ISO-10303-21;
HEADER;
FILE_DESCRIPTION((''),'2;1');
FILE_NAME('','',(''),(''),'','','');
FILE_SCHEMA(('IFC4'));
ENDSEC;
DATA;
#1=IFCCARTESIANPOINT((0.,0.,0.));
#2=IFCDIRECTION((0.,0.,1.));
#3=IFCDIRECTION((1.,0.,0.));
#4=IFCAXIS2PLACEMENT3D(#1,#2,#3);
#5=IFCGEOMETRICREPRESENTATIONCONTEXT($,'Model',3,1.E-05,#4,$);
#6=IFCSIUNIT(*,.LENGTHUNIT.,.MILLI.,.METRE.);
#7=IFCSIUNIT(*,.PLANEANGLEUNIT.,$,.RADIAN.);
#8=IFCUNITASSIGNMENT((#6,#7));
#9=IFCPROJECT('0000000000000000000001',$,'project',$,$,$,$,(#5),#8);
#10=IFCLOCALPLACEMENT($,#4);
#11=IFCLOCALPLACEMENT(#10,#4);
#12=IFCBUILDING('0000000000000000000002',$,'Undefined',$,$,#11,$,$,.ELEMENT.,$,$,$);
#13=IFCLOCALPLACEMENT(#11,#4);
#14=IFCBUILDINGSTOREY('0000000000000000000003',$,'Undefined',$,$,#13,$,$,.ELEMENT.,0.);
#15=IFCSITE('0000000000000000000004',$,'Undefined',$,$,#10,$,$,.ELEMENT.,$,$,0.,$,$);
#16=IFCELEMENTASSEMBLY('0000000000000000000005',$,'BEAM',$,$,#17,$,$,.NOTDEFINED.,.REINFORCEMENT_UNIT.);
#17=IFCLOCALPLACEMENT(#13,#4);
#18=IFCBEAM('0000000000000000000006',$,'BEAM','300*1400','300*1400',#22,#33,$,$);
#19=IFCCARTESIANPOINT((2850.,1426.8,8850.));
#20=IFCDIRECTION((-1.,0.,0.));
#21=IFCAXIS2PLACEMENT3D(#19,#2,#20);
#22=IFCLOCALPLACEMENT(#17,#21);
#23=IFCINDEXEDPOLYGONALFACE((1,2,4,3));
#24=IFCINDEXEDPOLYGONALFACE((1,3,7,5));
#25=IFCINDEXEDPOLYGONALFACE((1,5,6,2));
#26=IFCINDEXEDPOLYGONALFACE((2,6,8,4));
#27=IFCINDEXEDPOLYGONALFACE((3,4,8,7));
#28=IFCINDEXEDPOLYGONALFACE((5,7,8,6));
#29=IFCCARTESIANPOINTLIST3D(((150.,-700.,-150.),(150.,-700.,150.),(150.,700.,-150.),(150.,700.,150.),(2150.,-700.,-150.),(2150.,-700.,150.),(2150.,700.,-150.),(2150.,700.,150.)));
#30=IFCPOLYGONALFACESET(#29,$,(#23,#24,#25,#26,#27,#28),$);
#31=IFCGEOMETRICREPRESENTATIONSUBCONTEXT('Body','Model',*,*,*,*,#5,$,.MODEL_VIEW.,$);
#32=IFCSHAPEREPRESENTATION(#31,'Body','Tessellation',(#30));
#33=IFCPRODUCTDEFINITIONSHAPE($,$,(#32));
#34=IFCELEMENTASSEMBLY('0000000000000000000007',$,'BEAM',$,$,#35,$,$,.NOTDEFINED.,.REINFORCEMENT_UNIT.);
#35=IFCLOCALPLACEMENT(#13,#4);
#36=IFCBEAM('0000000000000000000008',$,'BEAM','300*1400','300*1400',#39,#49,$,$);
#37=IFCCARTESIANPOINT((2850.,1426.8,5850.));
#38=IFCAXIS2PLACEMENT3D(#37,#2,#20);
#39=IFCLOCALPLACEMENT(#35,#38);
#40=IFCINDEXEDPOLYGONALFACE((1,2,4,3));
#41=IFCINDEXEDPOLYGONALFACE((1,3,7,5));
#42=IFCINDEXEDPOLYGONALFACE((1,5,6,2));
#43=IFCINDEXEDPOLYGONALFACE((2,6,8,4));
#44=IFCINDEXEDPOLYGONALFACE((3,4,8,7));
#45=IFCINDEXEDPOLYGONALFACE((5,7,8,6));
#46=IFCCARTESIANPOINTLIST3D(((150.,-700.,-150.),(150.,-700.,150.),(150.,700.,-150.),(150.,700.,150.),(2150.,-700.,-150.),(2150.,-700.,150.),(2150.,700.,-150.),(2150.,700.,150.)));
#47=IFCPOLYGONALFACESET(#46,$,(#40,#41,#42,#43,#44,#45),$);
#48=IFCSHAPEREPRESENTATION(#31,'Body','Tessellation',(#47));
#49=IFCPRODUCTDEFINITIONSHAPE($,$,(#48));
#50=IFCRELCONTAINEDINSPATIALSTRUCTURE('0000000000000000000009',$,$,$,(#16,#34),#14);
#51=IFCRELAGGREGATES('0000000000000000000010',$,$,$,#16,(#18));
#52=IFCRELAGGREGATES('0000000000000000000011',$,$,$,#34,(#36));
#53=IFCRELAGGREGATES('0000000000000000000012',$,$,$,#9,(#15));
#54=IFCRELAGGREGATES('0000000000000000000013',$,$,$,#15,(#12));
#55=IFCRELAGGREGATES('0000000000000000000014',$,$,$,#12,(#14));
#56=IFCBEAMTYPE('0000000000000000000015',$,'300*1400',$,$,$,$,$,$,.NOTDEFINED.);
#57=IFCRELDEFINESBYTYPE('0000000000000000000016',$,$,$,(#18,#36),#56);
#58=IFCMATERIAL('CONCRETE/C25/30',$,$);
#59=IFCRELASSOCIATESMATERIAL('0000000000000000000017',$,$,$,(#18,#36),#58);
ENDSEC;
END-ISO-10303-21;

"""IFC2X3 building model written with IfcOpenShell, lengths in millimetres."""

from ifc_helpers import new_model, si_unit, frame, origin_with_axes, origin_2d_with_axis, place, context, subcontext, project, spatial, rectangle, extrude, material, type_object, element, aggregate, save


model = new_model("IFC2X3")

# Units and contexts
model_context = context("Model", 3, precision=1e-05, world=origin_with_axes())
body_context = subcontext(model_context, "Body", "Model", "MODEL_VIEW")
ifc_project = project(units=[si_unit("LENGTHUNIT", "METRE", prefix="MILLI"), si_unit("PLANEANGLEUNIT", "RADIAN")], contexts=[model_context])

# Site, building, storey
site_placement = place(None, origin_with_axes())
site = spatial("IfcSite", under=ifc_project, at=site_placement, Name="Undefined", CompositionType="ELEMENT", RefElevation=0.0)
building_placement = place(site_placement, origin_with_axes())
building = spatial("IfcBuilding", under=site, at=building_placement, Name="Undefined", CompositionType="ELEMENT")
storey_placement = place(building_placement, origin_with_axes())
storey = spatial("IfcBuildingStorey", under=building, at=storey_placement, Name="Undefined", CompositionType="ELEMENT", Elevation=0.0)

# Shared definitions
ifc_material_1 = material(Name="CONCRETE/C25/30")

# Element assemblies, beams
assembly_1_placement = place(storey_placement, origin_with_axes())
assembly_1 = element("IfcElementAssembly", 1, at=assembly_1_placement, inside=storey, Name="BEAM", AssemblyPlace="NOTDEFINED", PredefinedType="REINFORCEMENT_UNIT")
beam_type_1 = type_object("IfcBeamType", Name="300*1400", PredefinedType="NOTDEFINED")
beam_1_placement = place(assembly_1_placement, frame((2850.0, 1426.8, 8850.0), z_axis=(0.0, 0.0, 1.0), x_axis=(-1.0, 0.0, 0.0)))
beam_1 = element("IfcBeam", 2, at=beam_1_placement, type_object=beam_type_1, material=ifc_material_1, Name="BEAM", Description="300*1400", ObjectType="300*1400", context=body_context, shape_type="SweptSolid", body=[
    extrude(rectangle(XDim=1400.0, YDim=300.0, at=origin_2d_with_axis()), frame((2150.0, 0.0, 0.0), z_axis=(-1.0, 0.0, 0.0), x_axis=(0.0, -1.0, 0.0)), (0.0, 0.0, 1.0), 2000.0),
])
aggregate(assembly_1, [beam_1])
assembly_2_placement = place(storey_placement, origin_with_axes())
assembly_2 = element("IfcElementAssembly", 3, at=assembly_2_placement, inside=storey, Name="BEAM", AssemblyPlace="NOTDEFINED", PredefinedType="REINFORCEMENT_UNIT")
beam_2_placement = place(assembly_2_placement, frame((2850.0, 1426.8, 5850.0), z_axis=(0.0, 0.0, 1.0), x_axis=(-1.0, 0.0, 0.0)))
beam_2 = element("IfcBeam", 4, at=beam_2_placement, type_object=beam_type_1, material=ifc_material_1, Name="BEAM", Description="300*1400", ObjectType="300*1400", context=body_context, shape_type="SweptSolid", body=[
    extrude(rectangle(XDim=1400.0, YDim=300.0, at=origin_2d_with_axis()), frame((2150.0, 0.0, 0.0), z_axis=(-1.0, 0.0, 0.0), x_axis=(0.0, -1.0, 0.0)), (0.0, 0.0, 1.0), 2000.0),
])
aggregate(assembly_2, [beam_2])

save(model, "model.ifc")
